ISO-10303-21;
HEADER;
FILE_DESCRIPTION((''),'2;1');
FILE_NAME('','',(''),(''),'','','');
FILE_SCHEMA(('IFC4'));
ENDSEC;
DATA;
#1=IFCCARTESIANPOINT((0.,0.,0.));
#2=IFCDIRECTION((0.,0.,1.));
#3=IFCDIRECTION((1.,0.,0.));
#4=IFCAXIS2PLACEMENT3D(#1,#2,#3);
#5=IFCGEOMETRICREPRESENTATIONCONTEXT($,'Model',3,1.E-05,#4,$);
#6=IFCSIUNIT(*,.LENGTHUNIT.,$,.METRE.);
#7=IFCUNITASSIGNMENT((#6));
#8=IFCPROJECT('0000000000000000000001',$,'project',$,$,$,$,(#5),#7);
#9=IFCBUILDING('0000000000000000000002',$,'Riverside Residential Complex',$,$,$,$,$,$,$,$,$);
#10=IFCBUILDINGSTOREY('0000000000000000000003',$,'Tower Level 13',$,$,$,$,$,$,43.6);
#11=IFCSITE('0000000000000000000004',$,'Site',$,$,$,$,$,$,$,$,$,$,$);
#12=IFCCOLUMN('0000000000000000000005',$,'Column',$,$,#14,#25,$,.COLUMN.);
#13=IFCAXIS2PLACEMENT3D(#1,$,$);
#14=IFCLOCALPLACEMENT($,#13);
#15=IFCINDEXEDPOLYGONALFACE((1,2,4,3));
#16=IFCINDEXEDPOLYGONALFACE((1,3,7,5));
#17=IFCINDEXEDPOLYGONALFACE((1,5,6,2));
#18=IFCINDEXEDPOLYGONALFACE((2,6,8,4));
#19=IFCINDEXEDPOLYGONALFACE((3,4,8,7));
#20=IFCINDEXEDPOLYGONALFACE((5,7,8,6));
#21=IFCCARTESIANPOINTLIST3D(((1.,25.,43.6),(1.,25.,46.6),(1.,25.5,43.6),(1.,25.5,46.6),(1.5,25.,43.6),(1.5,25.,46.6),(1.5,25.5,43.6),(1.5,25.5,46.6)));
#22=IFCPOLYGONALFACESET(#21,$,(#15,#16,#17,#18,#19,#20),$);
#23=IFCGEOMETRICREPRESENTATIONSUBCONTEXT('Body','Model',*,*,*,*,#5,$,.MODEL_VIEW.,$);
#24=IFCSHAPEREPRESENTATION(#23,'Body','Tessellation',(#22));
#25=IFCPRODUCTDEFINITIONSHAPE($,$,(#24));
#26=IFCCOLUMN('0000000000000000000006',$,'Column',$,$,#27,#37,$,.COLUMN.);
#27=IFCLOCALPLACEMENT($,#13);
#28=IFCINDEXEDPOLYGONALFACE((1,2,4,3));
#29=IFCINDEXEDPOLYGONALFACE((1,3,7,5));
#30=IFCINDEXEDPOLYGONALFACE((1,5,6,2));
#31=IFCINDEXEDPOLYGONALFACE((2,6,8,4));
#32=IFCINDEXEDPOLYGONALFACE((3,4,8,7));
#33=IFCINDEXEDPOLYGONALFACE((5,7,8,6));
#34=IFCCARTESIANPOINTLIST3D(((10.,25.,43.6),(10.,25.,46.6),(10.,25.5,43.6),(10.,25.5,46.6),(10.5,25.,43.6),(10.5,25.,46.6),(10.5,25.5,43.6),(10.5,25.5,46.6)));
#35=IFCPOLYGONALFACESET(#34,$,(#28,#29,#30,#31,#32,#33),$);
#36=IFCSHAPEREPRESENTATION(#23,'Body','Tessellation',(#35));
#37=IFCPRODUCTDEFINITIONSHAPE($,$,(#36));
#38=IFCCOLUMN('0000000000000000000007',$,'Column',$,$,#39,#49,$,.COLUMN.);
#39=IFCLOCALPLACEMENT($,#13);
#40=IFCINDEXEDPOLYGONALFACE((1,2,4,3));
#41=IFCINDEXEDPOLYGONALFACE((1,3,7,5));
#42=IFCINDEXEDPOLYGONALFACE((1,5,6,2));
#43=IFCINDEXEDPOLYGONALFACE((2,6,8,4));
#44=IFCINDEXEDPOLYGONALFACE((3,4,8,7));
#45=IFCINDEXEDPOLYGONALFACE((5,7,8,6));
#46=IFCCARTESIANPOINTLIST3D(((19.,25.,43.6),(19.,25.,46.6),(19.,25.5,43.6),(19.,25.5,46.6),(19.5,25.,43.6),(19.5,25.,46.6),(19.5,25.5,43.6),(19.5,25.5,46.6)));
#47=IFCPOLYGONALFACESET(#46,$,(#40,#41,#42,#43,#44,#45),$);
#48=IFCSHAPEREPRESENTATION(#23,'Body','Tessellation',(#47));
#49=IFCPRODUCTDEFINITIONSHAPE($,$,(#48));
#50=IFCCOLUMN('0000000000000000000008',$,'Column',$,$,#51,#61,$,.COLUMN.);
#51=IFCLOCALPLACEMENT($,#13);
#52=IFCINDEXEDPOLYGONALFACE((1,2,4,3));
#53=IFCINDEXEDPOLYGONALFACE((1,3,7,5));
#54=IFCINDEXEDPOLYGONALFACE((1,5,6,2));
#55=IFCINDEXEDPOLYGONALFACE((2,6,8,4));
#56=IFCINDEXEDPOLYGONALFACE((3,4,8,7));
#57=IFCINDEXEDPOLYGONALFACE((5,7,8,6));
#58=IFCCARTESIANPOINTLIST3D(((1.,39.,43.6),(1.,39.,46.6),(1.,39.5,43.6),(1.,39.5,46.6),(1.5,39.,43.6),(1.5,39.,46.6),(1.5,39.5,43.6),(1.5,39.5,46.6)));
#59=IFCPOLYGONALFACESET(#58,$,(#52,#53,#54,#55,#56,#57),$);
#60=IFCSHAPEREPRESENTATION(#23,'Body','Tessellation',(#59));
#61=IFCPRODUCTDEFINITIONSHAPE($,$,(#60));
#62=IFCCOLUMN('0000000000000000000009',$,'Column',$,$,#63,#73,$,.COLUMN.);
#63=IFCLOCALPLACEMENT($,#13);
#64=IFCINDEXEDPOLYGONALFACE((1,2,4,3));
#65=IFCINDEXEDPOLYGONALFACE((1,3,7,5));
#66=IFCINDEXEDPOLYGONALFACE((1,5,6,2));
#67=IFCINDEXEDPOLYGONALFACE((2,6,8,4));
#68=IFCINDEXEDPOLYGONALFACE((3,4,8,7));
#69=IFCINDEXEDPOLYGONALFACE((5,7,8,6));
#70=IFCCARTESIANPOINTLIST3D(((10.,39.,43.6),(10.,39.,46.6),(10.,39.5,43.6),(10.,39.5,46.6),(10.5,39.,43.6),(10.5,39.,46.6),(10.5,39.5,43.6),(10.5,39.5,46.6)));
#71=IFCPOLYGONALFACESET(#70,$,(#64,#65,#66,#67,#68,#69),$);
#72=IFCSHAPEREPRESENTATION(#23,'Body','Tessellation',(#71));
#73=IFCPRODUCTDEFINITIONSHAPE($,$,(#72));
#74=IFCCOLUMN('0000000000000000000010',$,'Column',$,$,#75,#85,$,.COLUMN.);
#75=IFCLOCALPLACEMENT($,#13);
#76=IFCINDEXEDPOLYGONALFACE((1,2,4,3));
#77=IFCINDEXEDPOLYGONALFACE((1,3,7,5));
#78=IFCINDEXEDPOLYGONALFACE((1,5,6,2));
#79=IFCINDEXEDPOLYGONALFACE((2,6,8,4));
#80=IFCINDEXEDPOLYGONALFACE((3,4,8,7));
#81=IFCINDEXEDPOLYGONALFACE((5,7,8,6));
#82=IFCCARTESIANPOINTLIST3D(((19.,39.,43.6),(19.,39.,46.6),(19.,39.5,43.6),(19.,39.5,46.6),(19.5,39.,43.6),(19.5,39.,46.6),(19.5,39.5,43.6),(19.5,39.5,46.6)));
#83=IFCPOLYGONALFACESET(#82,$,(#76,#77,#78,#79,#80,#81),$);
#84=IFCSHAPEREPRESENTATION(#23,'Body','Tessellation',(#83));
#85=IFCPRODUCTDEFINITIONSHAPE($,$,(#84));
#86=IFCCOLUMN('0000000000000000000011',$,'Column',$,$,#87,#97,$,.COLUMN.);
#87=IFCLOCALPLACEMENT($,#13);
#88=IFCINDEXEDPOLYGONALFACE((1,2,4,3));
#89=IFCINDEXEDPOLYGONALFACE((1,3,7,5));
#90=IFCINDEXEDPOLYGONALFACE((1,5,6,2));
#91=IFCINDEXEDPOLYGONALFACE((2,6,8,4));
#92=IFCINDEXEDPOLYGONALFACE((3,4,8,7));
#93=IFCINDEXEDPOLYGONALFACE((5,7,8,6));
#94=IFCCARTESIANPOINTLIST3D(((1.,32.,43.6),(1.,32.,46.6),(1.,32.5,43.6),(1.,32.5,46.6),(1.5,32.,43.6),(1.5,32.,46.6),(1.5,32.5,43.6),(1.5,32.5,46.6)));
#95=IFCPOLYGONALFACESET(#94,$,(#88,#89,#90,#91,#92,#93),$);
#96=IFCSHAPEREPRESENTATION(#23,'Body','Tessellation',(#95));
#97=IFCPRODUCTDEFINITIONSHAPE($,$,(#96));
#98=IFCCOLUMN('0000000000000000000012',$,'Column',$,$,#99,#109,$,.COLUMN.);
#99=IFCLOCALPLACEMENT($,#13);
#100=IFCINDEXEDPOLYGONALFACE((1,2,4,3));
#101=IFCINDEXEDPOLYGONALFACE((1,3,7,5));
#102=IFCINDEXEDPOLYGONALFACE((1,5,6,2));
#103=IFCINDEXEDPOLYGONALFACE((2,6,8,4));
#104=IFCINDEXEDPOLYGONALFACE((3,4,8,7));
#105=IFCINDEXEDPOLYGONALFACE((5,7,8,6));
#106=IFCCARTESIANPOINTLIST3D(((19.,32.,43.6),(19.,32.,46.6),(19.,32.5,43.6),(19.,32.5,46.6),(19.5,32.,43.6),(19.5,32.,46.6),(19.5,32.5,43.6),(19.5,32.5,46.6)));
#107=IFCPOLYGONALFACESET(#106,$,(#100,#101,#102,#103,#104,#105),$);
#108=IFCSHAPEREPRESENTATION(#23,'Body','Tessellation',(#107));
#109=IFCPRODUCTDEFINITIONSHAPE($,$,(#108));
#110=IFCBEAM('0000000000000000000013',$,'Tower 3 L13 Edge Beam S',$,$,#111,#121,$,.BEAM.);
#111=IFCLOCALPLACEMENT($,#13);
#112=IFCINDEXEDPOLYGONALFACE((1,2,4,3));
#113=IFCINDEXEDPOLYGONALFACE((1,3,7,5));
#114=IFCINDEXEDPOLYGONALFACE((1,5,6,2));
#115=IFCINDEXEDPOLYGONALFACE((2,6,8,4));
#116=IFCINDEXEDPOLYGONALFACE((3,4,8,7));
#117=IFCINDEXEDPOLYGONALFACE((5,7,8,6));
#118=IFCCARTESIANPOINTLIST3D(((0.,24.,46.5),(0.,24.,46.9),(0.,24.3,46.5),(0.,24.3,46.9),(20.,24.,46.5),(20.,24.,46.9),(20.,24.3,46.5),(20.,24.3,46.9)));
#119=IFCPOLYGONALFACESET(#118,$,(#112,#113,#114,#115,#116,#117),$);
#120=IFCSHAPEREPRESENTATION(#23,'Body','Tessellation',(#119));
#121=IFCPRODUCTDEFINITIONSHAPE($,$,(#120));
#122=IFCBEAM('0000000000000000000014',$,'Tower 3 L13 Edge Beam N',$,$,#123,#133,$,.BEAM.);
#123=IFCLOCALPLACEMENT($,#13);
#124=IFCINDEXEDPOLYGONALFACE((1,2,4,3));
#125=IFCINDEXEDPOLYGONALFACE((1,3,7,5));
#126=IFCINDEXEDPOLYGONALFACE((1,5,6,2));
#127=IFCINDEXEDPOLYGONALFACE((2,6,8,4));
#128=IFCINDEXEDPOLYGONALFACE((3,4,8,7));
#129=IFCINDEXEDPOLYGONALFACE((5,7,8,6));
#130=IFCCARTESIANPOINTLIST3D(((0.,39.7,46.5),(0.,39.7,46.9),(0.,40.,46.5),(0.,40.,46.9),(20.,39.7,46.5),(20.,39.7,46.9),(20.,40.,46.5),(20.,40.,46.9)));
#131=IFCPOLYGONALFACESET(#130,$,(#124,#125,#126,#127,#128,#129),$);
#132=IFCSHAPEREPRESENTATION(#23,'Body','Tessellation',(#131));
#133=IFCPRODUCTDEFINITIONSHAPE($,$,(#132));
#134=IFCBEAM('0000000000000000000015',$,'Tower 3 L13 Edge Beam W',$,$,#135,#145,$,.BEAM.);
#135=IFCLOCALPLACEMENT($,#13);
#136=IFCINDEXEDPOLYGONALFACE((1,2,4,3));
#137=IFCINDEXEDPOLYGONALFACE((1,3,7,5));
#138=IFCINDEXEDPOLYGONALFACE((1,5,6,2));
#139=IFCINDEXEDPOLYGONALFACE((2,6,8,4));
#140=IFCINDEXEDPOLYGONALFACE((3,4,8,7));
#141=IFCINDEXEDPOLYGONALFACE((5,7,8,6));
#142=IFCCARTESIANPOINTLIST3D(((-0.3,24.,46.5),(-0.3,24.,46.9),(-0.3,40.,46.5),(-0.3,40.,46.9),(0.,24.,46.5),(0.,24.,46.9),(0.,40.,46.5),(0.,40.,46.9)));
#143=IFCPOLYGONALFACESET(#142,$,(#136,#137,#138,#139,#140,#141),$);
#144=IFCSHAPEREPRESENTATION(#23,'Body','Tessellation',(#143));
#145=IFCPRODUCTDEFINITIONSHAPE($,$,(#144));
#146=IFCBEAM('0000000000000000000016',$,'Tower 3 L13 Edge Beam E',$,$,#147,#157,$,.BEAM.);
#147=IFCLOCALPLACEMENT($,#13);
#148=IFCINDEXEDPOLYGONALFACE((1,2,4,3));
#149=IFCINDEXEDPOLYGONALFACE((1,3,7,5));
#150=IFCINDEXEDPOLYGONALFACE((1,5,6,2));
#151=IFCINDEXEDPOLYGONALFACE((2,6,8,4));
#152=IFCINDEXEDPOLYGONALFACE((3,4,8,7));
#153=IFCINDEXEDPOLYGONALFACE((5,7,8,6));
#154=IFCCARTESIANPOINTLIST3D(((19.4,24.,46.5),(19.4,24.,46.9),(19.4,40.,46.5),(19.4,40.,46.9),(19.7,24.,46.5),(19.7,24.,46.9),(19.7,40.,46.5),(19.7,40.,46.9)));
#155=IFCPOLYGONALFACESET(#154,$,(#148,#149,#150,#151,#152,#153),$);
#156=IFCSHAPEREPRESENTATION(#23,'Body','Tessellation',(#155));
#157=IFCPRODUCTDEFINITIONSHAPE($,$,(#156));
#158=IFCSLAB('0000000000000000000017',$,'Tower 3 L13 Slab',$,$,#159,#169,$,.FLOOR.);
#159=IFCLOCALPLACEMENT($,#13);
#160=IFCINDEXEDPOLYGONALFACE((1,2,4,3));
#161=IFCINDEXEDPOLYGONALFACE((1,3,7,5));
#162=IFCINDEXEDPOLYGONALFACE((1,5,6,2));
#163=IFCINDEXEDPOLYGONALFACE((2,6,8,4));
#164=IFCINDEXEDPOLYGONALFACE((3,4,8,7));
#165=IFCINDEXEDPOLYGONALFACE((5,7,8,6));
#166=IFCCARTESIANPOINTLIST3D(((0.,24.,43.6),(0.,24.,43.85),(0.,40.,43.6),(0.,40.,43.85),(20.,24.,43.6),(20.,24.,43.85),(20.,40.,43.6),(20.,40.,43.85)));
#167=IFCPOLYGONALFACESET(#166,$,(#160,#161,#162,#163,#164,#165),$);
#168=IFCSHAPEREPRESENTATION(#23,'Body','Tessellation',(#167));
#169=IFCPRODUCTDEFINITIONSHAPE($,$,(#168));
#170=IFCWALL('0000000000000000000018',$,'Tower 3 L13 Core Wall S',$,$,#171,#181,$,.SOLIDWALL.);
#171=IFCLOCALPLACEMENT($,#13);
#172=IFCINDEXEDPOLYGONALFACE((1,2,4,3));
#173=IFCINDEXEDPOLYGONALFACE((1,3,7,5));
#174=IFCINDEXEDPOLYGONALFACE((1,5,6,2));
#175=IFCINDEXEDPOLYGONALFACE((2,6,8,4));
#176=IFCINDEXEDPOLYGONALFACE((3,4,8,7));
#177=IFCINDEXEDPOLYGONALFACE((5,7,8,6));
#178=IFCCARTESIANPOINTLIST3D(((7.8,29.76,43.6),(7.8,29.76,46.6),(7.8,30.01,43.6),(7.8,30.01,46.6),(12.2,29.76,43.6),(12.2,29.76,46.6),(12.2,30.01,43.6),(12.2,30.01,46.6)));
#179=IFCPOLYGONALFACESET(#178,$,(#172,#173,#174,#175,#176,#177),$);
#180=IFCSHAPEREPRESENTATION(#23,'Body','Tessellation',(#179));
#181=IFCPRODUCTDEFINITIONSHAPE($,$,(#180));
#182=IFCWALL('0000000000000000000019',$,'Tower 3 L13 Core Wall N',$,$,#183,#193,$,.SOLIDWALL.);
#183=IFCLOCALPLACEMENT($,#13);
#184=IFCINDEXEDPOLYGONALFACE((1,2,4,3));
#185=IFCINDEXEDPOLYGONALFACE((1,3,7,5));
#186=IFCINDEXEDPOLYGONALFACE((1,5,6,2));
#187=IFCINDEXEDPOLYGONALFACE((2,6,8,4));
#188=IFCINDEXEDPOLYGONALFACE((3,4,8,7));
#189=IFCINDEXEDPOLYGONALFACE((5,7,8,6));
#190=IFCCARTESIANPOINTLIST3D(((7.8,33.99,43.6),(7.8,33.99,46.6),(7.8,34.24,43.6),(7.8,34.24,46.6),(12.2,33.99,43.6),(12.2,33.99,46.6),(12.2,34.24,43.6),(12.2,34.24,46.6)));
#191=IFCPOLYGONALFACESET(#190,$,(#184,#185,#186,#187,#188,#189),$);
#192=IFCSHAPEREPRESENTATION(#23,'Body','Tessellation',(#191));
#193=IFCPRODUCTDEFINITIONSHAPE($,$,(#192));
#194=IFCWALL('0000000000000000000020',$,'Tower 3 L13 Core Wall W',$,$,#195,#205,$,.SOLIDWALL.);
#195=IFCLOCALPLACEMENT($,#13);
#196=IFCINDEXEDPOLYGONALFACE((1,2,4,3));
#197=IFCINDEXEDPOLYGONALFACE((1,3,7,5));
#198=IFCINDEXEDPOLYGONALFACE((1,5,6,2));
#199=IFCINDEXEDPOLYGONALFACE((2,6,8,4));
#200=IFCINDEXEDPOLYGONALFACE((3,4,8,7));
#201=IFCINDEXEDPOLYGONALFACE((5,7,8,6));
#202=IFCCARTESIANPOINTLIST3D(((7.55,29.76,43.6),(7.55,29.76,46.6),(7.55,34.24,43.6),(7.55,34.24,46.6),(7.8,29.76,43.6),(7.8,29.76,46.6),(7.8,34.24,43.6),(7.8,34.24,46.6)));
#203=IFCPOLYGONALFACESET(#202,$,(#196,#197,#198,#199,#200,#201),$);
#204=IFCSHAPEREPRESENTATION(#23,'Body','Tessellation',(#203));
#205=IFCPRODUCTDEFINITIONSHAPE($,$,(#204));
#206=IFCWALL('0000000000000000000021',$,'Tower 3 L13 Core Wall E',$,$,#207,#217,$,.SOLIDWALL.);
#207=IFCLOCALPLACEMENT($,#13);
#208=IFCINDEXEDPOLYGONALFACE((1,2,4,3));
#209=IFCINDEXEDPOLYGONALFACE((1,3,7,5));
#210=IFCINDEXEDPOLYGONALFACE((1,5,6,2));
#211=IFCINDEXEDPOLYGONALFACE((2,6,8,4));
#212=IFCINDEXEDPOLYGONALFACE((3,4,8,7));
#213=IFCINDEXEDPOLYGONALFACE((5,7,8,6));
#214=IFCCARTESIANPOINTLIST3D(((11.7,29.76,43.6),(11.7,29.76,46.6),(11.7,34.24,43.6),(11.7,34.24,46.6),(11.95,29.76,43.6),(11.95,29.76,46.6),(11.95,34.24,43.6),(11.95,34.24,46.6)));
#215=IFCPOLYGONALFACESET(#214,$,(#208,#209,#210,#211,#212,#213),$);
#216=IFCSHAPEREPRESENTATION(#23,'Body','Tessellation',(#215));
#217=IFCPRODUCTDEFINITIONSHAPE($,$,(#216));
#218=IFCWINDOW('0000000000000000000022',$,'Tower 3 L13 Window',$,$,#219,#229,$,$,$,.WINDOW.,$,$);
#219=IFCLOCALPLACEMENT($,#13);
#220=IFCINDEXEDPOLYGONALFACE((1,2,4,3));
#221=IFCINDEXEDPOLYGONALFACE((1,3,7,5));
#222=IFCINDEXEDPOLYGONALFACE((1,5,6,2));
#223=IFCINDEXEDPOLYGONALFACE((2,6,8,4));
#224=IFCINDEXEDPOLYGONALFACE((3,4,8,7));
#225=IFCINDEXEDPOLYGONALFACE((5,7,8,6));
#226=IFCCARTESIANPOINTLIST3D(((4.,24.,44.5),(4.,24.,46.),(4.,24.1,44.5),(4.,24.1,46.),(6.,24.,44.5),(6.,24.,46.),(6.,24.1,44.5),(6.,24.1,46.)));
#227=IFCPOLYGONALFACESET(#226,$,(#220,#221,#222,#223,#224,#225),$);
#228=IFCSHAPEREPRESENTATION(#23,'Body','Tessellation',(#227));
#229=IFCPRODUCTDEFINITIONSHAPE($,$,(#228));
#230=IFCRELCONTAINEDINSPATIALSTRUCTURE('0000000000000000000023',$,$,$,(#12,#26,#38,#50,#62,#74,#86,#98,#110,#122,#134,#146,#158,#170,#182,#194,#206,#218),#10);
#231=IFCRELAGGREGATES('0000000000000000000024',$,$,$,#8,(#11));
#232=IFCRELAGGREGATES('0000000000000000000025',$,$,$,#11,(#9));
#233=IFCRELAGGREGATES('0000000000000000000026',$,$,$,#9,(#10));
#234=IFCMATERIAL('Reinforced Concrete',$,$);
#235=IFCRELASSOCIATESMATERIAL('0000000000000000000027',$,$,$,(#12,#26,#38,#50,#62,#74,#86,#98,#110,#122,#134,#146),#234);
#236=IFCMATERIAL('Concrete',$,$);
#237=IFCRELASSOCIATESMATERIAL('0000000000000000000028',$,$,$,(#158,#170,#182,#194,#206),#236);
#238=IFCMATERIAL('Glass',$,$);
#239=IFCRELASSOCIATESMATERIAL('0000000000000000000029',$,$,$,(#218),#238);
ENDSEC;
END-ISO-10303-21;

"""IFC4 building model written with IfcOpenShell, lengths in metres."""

from ifc_helpers import new_model, si_unit, frame, origin_with_axes, place, context, subcontext, project, spatial, line, indexed_curve, outline, extrude, material, element, save


model = new_model("IFC4")

# Units and contexts
model_context = context("Model", 3, precision=1e-05, world=origin_with_axes())
body_context = subcontext(model_context, "Body", "Model", "MODEL_VIEW")
ifc_project = project(units=[si_unit("LENGTHUNIT", "METRE")], contexts=[model_context])

# Site, building, storey
site = spatial("IfcSite", under=ifc_project, Name="Site")
building = spatial("IfcBuilding", under=site, Name="Riverside Residential Complex")
storey = spatial("IfcBuildingStorey", under=building, Name="Tower Level 13", Elevation=43.6)

# Columns
ifc_material_1 = material(Name="Reinforced Concrete")
for number, where, z_axis, x_axis, name in (
    (1, (1.0, 25.0, 43.6), (0.0, 0.0, 1.0), (1.0, 0.0, 0.0), "Column"),
    (2, (10.0, 25.0, 43.6), (0.0, 0.0, 1.0), (1.0, 0.0, 0.0), "Column"),
    (3, (19.0, 25.0, 43.6), (0.0, 0.0, 1.0), (1.0, 0.0, 0.0), "Column"),
    (4, (1.0, 39.0, 43.6), (0.0, 0.0, 1.0), (1.0, 0.0, 0.0), "Column"),
    (5, (10.0, 39.0, 43.6), (0.0, 0.0, 1.0), (1.0, 0.0, 0.0), "Column"),
    (6, (19.0, 39.0, 43.6), (0.0, 0.0, 1.0), (1.0, 0.0, 0.0), "Column"),
    (7, (1.0, 32.0, 43.6), (0.0, 0.0, 1.0), (1.0, 0.0, 0.0), "Column"),
    (8, (19.0, 32.0, 43.6), (0.0, 0.0, 1.0), (1.0, 0.0, 0.0), "Column"),
):
    element("IfcColumn", number, at=place(None, frame(where, z_axis=z_axis, x_axis=x_axis)), inside=storey, material=ifc_material_1, Name=name, PredefinedType="COLUMN", context=body_context, shape_type="SweptSolid", body=[
        extrude(outline(indexed_curve([(0.0, 0.0), (0.5, 0.0), (0.5, 0.5), (0.0, 0.5)], segments=[line(1, 2, 3, 4, 1)])), origin_with_axes(), (0.0, 0.0, 1.0), 3.0),
    ])

# Beams
for number, where, z_axis, x_axis, name in (
    (9, (0.0, 24.0, 46.5), (0.0, 0.0, 1.0), (1.0, 0.0, 0.0), "Tower 3 L13 Edge Beam S"),
    (10, (0.0, 39.7, 46.5), (0.0, 0.0, 1.0), (1.0, 0.0, 0.0), "Tower 3 L13 Edge Beam N"),
):
    element("IfcBeam", number, at=place(None, frame(where, z_axis=z_axis, x_axis=x_axis)), inside=storey, material=ifc_material_1, Name=name, PredefinedType="BEAM", context=body_context, shape_type="SweptSolid", body=[
        extrude(outline(indexed_curve([(0.0, 0.0), (20.0, 0.0), (20.0, 0.3), (0.0, 0.3)], segments=[line(1, 2, 3, 4, 1)])), origin_with_axes(), (0.0, 0.0, 1.0), 0.4),
    ])
for number, where, z_axis, x_axis, name in (
    (11, (0.0, 24.0, 46.5), (0.0, 0.0, 1.0), (0.0, 1.0, 0.0), "Tower 3 L13 Edge Beam W"),
    (12, (19.7, 24.0, 46.5), (0.0, 0.0, 1.0), (0.0, 1.0, 0.0), "Tower 3 L13 Edge Beam E"),
):
    element("IfcBeam", number, at=place(None, frame(where, z_axis=z_axis, x_axis=x_axis)), inside=storey, material=ifc_material_1, Name=name, PredefinedType="BEAM", context=body_context, shape_type="SweptSolid", body=[
        extrude(outline(indexed_curve([(0.0, 0.0), (16.0, 0.0), (16.0, 0.3), (0.0, 0.3)], segments=[line(1, 2, 3, 4, 1)])), origin_with_axes(), (0.0, 0.0, 1.0), 0.4),
    ])

# Slab
ifc_material_2 = material(Name="Concrete")
slab_placement = place(None, frame((0.0, 24.0, 43.6), z_axis=(0.0, 0.0, 1.0), x_axis=(1.0, 0.0, 0.0)))
element("IfcSlab", 13, at=slab_placement, inside=storey, material=ifc_material_2, Name="Tower 3 L13 Slab", PredefinedType="FLOOR", context=body_context, shape_type="SweptSolid", body=[
    extrude(outline(indexed_curve([(0.0, 0.0), (20.0, 0.0), (20.0, 16.0), (0.0, 16.0)], segments=[line(1, 2, 3, 4, 1)])), origin_with_axes(), (0.0, 0.0, 1.0), 0.25),
])

# Walls
for number, where, z_axis, x_axis, name in (
    (14, (7.8, 29.76, 43.6), (0.0, 0.0, 1.0), (1.0, 0.0, 0.0), "Tower 3 L13 Core Wall S"),
    (15, (7.8, 33.99, 43.6), (0.0, 0.0, 1.0), (1.0, 0.0, 0.0), "Tower 3 L13 Core Wall N"),
):
    element("IfcWall", number, at=place(None, frame(where, z_axis=z_axis, x_axis=x_axis)), inside=storey, material=ifc_material_2, Name=name, PredefinedType="SOLIDWALL", context=body_context, shape_type="SweptSolid", body=[
        extrude(outline(indexed_curve([(0.0, 0.0), (4.4, 0.0), (4.4, 0.25), (0.0, 0.25)], segments=[line(1, 2, 3, 4, 1)])), origin_with_axes(), (0.0, 0.0, 1.0), 3.0),
    ])
for number, where, z_axis, x_axis, name in (
    (16, (7.8, 29.76, 43.6), (0.0, 0.0, 1.0), (0.0, 1.0, 0.0), "Tower 3 L13 Core Wall W"),
    (17, (11.95, 29.76, 43.6), (0.0, 0.0, 1.0), (0.0, 1.0, 0.0), "Tower 3 L13 Core Wall E"),
):
    element("IfcWall", number, at=place(None, frame(where, z_axis=z_axis, x_axis=x_axis)), inside=storey, material=ifc_material_2, Name=name, PredefinedType="SOLIDWALL", context=body_context, shape_type="SweptSolid", body=[
        extrude(outline(indexed_curve([(0.0, 0.0), (4.48, 0.0), (4.48, 0.25), (0.0, 0.25)], segments=[line(1, 2, 3, 4, 1)])), origin_with_axes(), (0.0, 0.0, 1.0), 3.0),
    ])

# Window
ifc_material_3 = material(Name="Glass")
for number, where, z_axis, x_axis, name in (
    (18, (4.0, 24.0, 44.5), (0.0, 0.0, 1.0), (1.0, 0.0, 0.0), "Tower 3 L13 Window"),
):
    element("IfcWindow", number, at=place(None, frame(where, z_axis=z_axis, x_axis=x_axis)), inside=storey, material=ifc_material_3, Name=name, PredefinedType="WINDOW", context=body_context, shape_type="SweptSolid", body=[
        extrude(outline(indexed_curve([(0.0, 0.0), (2.0, 0.0), (2.0, 0.1), (0.0, 0.1)], segments=[line(1, 2, 3, 4, 1)])), origin_with_axes(), (0.0, 0.0, 1.0), 1.5),
    ])

save(model, "model.ifc")
